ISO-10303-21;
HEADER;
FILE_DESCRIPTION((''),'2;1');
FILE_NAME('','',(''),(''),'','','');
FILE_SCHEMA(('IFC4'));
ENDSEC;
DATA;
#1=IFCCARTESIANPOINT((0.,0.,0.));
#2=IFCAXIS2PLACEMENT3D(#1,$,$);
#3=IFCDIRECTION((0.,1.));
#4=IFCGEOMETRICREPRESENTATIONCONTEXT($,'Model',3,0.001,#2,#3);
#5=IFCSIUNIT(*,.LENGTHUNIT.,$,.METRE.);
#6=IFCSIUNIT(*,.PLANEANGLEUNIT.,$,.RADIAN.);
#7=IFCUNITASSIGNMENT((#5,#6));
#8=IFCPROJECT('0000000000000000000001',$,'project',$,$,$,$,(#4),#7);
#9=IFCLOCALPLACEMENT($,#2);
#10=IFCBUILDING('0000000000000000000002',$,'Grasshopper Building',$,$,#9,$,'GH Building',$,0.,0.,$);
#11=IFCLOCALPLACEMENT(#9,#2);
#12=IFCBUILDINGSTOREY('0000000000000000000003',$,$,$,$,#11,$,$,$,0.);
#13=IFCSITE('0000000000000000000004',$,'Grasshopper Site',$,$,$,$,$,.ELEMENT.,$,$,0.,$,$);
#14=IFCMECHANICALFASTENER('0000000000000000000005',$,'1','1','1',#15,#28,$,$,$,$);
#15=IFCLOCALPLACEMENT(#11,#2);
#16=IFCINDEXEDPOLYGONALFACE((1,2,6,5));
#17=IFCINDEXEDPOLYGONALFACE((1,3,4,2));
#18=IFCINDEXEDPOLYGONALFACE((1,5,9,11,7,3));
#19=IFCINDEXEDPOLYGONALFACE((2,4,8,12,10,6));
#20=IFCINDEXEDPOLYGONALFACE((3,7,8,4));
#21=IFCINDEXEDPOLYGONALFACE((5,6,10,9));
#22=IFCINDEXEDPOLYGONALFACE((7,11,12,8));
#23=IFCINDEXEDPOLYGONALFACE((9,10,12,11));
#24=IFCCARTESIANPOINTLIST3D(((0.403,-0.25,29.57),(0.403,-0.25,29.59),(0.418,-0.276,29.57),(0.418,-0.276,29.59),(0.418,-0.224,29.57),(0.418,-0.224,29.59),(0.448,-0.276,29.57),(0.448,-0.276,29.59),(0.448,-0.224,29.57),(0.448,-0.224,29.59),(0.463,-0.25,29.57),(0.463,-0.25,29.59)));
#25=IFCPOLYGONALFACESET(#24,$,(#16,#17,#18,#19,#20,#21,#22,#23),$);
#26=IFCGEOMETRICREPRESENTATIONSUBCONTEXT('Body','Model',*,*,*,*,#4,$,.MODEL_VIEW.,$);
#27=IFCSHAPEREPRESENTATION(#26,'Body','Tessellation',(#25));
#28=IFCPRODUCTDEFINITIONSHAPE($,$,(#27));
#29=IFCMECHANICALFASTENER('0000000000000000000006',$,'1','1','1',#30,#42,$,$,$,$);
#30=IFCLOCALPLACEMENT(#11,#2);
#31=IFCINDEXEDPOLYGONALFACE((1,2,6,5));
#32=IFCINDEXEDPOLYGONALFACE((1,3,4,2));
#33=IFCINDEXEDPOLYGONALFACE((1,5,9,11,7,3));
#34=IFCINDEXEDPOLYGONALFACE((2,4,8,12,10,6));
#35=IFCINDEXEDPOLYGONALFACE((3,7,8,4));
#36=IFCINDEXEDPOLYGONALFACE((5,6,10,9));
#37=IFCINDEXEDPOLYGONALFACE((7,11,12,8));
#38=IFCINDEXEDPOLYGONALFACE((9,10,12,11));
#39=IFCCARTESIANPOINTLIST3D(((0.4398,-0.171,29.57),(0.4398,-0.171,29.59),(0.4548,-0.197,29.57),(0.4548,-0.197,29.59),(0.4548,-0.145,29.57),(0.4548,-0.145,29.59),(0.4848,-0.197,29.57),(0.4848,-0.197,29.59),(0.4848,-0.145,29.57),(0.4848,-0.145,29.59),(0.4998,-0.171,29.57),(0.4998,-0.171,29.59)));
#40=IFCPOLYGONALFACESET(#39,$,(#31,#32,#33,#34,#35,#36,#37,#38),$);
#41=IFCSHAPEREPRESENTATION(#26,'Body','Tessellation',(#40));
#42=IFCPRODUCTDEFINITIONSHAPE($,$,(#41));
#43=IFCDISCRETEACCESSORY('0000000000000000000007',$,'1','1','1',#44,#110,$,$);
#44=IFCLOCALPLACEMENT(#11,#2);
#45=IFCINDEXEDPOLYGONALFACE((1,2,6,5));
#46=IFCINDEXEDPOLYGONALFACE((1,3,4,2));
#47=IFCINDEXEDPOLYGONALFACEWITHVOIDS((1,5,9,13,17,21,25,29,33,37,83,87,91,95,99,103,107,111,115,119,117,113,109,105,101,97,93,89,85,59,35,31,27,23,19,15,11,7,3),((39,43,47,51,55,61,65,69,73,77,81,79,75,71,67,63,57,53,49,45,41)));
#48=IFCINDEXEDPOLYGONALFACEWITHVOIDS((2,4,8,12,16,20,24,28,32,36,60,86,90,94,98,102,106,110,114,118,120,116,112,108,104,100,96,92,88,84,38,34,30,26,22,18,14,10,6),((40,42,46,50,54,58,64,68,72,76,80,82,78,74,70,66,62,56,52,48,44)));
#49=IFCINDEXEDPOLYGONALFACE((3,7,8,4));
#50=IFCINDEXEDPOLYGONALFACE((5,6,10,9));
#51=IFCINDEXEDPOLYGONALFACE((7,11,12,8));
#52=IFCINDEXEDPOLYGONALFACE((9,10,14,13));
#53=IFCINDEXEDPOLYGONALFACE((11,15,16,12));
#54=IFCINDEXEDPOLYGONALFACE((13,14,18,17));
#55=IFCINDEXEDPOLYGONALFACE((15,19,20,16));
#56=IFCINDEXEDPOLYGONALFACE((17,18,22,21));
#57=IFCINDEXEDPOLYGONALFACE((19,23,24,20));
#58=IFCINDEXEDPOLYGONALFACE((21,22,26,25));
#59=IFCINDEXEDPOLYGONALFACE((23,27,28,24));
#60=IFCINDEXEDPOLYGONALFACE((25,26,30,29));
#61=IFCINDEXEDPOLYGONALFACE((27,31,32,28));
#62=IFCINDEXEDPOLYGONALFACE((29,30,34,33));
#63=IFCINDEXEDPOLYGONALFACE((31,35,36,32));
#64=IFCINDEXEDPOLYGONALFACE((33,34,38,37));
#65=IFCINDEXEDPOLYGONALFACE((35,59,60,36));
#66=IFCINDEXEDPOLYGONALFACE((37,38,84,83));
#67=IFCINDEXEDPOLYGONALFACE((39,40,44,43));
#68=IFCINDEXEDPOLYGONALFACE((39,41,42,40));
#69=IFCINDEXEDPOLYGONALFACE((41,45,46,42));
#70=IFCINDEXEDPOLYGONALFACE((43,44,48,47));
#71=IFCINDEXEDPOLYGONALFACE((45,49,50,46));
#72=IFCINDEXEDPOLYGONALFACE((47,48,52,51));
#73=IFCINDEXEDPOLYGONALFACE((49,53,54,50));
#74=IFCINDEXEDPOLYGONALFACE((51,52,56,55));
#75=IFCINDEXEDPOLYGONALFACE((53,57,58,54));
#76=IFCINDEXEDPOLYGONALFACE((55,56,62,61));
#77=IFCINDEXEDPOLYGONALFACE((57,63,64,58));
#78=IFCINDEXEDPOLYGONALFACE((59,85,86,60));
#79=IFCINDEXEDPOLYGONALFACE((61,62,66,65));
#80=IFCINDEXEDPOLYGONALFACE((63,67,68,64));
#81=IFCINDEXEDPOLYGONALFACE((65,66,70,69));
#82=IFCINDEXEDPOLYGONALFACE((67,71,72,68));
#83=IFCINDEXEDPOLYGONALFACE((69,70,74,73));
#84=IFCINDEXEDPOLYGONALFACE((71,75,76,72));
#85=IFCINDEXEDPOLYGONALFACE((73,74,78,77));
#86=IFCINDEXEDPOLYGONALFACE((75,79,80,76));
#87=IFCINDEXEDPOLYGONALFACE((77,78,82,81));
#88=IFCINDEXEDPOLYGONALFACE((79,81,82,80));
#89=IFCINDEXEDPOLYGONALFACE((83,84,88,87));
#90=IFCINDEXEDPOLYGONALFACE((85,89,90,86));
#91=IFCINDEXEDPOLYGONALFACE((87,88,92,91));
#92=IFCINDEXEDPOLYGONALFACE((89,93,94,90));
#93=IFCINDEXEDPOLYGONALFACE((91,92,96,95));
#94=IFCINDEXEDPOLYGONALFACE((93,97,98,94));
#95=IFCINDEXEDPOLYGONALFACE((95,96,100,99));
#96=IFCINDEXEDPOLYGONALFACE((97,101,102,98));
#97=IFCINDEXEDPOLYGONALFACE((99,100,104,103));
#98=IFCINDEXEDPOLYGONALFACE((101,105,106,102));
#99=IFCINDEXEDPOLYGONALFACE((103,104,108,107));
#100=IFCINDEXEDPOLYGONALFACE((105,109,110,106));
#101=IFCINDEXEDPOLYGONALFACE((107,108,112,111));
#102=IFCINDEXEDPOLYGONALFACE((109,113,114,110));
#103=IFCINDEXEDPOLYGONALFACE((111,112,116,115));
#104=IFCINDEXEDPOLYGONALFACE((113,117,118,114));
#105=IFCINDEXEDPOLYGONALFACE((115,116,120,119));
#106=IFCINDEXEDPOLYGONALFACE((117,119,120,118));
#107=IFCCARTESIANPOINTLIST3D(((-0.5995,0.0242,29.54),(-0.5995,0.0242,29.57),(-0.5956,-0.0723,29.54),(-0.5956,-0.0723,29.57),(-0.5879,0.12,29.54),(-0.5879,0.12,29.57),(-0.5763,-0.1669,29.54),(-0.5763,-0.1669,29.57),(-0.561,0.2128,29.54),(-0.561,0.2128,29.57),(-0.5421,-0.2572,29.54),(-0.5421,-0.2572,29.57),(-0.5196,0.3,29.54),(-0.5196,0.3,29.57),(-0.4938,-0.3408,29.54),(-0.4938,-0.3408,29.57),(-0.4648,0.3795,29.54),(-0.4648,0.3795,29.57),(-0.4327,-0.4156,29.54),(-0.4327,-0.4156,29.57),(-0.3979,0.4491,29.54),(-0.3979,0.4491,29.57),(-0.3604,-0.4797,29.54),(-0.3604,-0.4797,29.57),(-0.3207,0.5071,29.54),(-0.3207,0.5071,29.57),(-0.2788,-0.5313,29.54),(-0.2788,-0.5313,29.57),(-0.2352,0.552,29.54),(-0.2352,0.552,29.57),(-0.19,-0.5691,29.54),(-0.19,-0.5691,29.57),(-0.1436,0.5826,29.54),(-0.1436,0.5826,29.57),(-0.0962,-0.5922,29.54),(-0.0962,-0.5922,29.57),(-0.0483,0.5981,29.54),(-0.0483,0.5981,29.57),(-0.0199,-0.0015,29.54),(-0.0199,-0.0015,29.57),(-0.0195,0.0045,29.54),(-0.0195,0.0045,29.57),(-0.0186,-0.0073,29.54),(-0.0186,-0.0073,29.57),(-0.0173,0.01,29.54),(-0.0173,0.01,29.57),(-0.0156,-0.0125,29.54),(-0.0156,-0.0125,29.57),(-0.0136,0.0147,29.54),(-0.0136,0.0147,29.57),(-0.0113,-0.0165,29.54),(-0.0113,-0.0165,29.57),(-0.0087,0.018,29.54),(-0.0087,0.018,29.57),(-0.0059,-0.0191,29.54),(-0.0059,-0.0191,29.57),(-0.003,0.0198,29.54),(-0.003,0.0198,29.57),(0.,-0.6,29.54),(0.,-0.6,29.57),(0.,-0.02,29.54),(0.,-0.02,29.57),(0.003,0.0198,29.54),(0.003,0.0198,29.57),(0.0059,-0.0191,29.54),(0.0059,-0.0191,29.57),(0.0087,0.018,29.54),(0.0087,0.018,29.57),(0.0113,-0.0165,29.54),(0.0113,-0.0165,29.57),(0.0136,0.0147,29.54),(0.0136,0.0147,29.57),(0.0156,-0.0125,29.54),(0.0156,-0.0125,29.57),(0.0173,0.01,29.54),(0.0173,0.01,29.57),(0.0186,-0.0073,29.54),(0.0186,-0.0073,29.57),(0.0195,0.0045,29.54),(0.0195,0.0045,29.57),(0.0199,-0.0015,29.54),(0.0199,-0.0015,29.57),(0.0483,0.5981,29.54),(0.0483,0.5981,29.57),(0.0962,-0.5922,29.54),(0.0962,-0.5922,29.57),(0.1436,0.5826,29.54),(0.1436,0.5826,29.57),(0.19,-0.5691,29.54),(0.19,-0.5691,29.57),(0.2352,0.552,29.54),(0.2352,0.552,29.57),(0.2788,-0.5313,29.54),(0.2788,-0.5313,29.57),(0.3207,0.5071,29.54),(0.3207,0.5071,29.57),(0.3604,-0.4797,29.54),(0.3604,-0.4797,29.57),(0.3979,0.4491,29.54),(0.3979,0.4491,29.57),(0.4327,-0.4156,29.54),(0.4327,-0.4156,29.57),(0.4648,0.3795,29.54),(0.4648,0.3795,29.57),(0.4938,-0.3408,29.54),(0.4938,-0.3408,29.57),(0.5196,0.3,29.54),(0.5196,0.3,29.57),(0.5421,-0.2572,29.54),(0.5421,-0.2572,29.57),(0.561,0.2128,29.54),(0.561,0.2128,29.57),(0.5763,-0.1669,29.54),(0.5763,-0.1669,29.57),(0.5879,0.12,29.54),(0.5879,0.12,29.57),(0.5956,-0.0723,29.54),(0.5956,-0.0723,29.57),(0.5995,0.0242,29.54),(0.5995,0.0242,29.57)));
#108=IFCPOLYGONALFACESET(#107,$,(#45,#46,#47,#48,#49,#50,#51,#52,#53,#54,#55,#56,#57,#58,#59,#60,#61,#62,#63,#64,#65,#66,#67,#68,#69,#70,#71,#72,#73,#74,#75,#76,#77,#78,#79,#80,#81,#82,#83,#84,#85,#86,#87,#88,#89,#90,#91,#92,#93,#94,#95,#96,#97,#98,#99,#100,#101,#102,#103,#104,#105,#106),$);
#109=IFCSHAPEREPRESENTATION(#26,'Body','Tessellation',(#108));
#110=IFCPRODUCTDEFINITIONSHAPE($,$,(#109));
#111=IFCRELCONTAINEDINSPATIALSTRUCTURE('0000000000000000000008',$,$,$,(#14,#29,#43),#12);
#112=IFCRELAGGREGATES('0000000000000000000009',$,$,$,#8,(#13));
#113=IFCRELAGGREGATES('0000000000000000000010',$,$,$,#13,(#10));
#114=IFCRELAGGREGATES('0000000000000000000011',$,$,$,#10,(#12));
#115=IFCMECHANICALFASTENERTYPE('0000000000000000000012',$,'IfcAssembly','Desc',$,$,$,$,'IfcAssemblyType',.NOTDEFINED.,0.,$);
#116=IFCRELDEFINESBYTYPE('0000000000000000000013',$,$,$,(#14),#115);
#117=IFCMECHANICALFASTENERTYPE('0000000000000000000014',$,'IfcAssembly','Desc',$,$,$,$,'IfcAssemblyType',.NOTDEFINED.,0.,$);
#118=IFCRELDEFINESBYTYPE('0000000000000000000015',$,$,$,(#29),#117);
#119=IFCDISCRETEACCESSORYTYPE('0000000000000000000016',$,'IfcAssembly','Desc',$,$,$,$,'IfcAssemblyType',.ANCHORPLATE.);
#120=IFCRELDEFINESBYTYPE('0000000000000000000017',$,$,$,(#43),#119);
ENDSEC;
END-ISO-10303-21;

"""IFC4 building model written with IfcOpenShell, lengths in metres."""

from ifc_helpers import new_model, si_unit, direction, frame, origin, place, context, subcontext, project, spatial, indexed_curve, hollow_circle, outline, extrude, source, transform, mapped, type_object, type_shapes, element, save


model = new_model("IFC4")

# Units and contexts
model_context = context("Model", 3, precision=0.001, world=origin(), true_north=direction((0.0, 1.0)))
body_context = subcontext(model_context, "Body", "Model", "MODEL_VIEW")
ifc_project = project(units=[si_unit("LENGTHUNIT", "METRE"), si_unit("PLANEANGLEUNIT", "RADIAN")], contexts=[model_context])

# Site, building, storey
site = spatial("IfcSite", under=ifc_project, Name="Grasshopper Site", CompositionType="ELEMENT", RefElevation=0.0)
building_placement = place(None, origin())
building = spatial("IfcBuilding", under=site, at=building_placement, Name="Grasshopper Building", LongName="GH Building", ElevationOfRefHeight=0.0, ElevationOfTerrain=0.0)
storey_placement = place(building_placement, origin())
storey = spatial("IfcBuildingStorey", under=building, at=storey_placement, Elevation=0.0)

# Mechanical fasteners
mechanical_fastener_type_1 = type_object("IfcMechanicalFastenerType", Name="IfcAssembly", Description="Desc", ElementType="IfcAssemblyType", NominalDiameter=0.0)
shared_shape_1 = source(origin(), body_context, "Body", "SweptSolid", [
    extrude(outline(indexed_curve([(0.03, 0.0), (0.015, 0.026), (-0.015, 0.026), (-0.03, 0.0), (-0.015, -0.026), (0.015, -0.026), (0.03, 0.0)])), frame((0.433, -0.25, 29.57)), (0.0, 0.0, 1.0), 0.02),
])
type_shapes(mechanical_fastener_type_1, [shared_shape_1])
mechanical_fastener_1_placement = place(storey_placement, origin())
element("IfcMechanicalFastener", 1, at=mechanical_fastener_1_placement, inside=storey, type_object=mechanical_fastener_type_1, Name="1", Description="1", ObjectType="1", context=body_context, shape_type="MappedRepresentation", body=[
    mapped(shared_shape_1, transform((0.0, 0.0, 0.0), scale=1.0)),
])
mechanical_fastener_type_2 = type_object("IfcMechanicalFastenerType", Name="IfcAssembly", Description="Desc", ElementType="IfcAssemblyType", NominalDiameter=0.0)
shared_shape_2 = source(origin(), body_context, "Body", "SweptSolid", [
    extrude(outline(indexed_curve([(0.03, 0.0), (0.015, 0.026), (-0.015, 0.026), (-0.03, 0.0), (-0.015, -0.026), (0.015, -0.026), (0.03, 0.0)])), frame((0.4698, -0.171, 29.57)), (0.0, 0.0, 1.0), 0.02),
])
type_shapes(mechanical_fastener_type_2, [shared_shape_2])
mechanical_fastener_2_placement = place(storey_placement, origin())
element("IfcMechanicalFastener", 2, at=mechanical_fastener_2_placement, inside=storey, type_object=mechanical_fastener_type_2, Name="1", Description="1", ObjectType="1", context=body_context, shape_type="MappedRepresentation", body=[
    mapped(shared_shape_2, transform((0.0, 0.0, 0.0), scale=1.0)),
])

# Discrete accessory
discrete_accessory_type = type_object("IfcDiscreteAccessoryType", Name="IfcAssembly", Description="Desc", ElementType="IfcAssemblyType", PredefinedType="ANCHORPLATE")
shared_shape_3 = source(origin(), body_context, "Body", "SweptSolid", [
    extrude(hollow_circle(Radius=0.6, WallThickness=0.58), frame((0.0, 0.0, 29.54), z_axis=(0.0, 0.0, 1.0), x_axis=(0.0, -1.0, 0.0)), (0.0, 0.0, 1.0), 0.03),
])
type_shapes(discrete_accessory_type, [shared_shape_3])
discrete_accessory_placement = place(storey_placement, origin())
element("IfcDiscreteAccessory", 3, at=discrete_accessory_placement, inside=storey, type_object=discrete_accessory_type, Name="1", Description="1", ObjectType="1", context=body_context, shape_type="MappedRepresentation", body=[
    mapped(shared_shape_3, transform((0.0, 0.0, 0.0), scale=1.0)),
])

save(model, "model.ifc")
